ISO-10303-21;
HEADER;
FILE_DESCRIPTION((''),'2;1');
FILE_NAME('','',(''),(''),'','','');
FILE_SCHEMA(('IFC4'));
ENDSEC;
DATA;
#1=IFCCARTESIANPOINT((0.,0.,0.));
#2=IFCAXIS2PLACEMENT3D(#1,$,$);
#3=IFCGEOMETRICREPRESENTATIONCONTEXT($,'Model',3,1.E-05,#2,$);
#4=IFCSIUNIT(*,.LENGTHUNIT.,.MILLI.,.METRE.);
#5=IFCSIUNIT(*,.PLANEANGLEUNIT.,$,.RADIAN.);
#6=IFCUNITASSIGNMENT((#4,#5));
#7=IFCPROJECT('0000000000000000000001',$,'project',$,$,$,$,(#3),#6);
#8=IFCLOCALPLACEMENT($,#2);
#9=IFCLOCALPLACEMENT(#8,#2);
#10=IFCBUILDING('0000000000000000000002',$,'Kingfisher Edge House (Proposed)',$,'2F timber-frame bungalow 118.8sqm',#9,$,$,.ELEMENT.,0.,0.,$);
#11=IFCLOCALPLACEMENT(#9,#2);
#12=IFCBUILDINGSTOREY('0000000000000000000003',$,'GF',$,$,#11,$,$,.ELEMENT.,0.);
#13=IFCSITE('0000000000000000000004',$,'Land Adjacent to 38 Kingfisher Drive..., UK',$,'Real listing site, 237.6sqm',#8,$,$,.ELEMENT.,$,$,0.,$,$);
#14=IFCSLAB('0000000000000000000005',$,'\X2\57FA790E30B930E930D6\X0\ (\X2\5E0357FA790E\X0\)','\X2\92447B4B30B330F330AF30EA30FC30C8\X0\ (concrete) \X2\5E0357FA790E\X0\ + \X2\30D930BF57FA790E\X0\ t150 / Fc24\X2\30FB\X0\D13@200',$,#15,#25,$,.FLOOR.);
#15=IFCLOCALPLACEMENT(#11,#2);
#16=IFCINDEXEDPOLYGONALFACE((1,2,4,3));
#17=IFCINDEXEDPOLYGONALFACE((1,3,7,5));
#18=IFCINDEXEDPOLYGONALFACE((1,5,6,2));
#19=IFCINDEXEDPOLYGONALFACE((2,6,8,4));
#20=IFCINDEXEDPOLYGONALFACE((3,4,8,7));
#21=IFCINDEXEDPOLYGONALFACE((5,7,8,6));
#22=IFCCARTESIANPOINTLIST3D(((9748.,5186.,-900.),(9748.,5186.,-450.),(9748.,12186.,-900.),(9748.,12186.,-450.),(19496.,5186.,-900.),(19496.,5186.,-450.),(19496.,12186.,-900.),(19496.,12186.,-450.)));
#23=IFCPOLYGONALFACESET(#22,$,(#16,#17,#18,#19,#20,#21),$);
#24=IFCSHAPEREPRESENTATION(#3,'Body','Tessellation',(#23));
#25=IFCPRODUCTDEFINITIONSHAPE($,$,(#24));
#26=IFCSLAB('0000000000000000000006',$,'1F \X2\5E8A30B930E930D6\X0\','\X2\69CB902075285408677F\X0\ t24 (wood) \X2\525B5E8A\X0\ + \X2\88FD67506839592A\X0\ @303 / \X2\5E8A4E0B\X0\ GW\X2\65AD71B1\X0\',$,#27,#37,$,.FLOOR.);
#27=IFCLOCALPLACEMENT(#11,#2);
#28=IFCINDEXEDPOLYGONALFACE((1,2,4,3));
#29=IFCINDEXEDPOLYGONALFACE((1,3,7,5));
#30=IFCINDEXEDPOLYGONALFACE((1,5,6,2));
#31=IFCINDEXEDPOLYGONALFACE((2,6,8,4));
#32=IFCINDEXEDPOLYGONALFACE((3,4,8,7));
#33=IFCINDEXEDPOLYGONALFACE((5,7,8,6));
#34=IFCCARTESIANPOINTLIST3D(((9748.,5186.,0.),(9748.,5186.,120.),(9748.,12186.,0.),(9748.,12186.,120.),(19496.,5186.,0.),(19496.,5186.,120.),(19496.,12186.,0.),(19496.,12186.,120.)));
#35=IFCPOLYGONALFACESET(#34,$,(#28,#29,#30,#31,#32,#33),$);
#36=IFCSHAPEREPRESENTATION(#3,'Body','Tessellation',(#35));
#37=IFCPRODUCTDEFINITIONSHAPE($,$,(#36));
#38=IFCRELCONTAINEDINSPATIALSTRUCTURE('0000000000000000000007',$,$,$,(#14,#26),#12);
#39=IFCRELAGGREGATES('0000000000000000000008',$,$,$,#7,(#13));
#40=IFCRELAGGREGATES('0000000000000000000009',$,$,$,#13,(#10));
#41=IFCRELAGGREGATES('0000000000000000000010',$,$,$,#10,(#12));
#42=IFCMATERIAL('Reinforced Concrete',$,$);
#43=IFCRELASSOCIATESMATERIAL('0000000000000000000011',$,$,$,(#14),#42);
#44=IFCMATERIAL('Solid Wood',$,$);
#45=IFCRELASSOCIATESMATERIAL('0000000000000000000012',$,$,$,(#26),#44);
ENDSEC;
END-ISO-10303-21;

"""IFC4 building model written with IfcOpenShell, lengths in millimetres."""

from ifc_helpers import new_model, si_unit, frame, frame_2d, origin, place, context, project, spatial, rectangle, extrude, material, element, save


model = new_model("IFC4")

# Units and contexts
model_context = context("Model", 3, precision=1e-05, world=origin())
ifc_project = project(units=[si_unit("LENGTHUNIT", "METRE", prefix="MILLI"), si_unit("PLANEANGLEUNIT", "RADIAN")], contexts=[model_context])

# Site, building, storey
site_placement = place(None, origin())
site = spatial("IfcSite", under=ifc_project, at=site_placement, Name="Land Adjacent to 38 Kingfisher Drive..., UK", ObjectType="Real listing site, 237.6sqm", CompositionType="ELEMENT", RefElevation=0.0)
building_placement = place(site_placement, origin())
building = spatial("IfcBuilding", under=site, at=building_placement, Name="Kingfisher Edge House (Proposed)", ObjectType="2F timber-frame bungalow 118.8sqm", CompositionType="ELEMENT", ElevationOfRefHeight=0.0, ElevationOfTerrain=0.0)
storey_placement = place(building_placement, origin())
storey = spatial("IfcBuildingStorey", under=building, at=storey_placement, Name="GF", CompositionType="ELEMENT", Elevation=0.0)

# Slabs
ifc_material_1 = material(Name="Reinforced Concrete")
slab_1_placement = place(storey_placement, frame((4874.0, 2593.0, -450.0)))
element("IfcSlab", 1, at=slab_1_placement, inside=storey, material=ifc_material_1, Name="基礎スラブ (布基礎)", Description="鉄筋コンクリート (concrete) 布基礎 + ベタ基礎 t150 / Fc24・D13@200", PredefinedType="FLOOR", context=model_context, shape_type="SweptSolid", body=[
    extrude(rectangle(XDim=9748.0, YDim=7000.0, at=frame_2d((4874.0, 3500.0))), frame((4874.0, 2593.0, -450.0)), (0.0, 0.0, 1.0), 450.0),
])
ifc_material_2 = material(Name="Solid Wood")
slab_2_placement = place(storey_placement, frame((4874.0, 2593.0, 0.0)))
element("IfcSlab", 2, at=slab_2_placement, inside=storey, material=ifc_material_2, Name="1F 床スラブ", Description="構造用合板 t24 (wood) 剛床 + 製材根太 @303 / 床下 GW断熱", PredefinedType="FLOOR", context=model_context, shape_type="SweptSolid", body=[
    extrude(rectangle(XDim=9748.0, YDim=7000.0, at=frame_2d((4874.0, 3500.0))), frame((4874.0, 2593.0, 0.0)), (0.0, 0.0, 1.0), 120.0),
])

save(model, "model.ifc")
